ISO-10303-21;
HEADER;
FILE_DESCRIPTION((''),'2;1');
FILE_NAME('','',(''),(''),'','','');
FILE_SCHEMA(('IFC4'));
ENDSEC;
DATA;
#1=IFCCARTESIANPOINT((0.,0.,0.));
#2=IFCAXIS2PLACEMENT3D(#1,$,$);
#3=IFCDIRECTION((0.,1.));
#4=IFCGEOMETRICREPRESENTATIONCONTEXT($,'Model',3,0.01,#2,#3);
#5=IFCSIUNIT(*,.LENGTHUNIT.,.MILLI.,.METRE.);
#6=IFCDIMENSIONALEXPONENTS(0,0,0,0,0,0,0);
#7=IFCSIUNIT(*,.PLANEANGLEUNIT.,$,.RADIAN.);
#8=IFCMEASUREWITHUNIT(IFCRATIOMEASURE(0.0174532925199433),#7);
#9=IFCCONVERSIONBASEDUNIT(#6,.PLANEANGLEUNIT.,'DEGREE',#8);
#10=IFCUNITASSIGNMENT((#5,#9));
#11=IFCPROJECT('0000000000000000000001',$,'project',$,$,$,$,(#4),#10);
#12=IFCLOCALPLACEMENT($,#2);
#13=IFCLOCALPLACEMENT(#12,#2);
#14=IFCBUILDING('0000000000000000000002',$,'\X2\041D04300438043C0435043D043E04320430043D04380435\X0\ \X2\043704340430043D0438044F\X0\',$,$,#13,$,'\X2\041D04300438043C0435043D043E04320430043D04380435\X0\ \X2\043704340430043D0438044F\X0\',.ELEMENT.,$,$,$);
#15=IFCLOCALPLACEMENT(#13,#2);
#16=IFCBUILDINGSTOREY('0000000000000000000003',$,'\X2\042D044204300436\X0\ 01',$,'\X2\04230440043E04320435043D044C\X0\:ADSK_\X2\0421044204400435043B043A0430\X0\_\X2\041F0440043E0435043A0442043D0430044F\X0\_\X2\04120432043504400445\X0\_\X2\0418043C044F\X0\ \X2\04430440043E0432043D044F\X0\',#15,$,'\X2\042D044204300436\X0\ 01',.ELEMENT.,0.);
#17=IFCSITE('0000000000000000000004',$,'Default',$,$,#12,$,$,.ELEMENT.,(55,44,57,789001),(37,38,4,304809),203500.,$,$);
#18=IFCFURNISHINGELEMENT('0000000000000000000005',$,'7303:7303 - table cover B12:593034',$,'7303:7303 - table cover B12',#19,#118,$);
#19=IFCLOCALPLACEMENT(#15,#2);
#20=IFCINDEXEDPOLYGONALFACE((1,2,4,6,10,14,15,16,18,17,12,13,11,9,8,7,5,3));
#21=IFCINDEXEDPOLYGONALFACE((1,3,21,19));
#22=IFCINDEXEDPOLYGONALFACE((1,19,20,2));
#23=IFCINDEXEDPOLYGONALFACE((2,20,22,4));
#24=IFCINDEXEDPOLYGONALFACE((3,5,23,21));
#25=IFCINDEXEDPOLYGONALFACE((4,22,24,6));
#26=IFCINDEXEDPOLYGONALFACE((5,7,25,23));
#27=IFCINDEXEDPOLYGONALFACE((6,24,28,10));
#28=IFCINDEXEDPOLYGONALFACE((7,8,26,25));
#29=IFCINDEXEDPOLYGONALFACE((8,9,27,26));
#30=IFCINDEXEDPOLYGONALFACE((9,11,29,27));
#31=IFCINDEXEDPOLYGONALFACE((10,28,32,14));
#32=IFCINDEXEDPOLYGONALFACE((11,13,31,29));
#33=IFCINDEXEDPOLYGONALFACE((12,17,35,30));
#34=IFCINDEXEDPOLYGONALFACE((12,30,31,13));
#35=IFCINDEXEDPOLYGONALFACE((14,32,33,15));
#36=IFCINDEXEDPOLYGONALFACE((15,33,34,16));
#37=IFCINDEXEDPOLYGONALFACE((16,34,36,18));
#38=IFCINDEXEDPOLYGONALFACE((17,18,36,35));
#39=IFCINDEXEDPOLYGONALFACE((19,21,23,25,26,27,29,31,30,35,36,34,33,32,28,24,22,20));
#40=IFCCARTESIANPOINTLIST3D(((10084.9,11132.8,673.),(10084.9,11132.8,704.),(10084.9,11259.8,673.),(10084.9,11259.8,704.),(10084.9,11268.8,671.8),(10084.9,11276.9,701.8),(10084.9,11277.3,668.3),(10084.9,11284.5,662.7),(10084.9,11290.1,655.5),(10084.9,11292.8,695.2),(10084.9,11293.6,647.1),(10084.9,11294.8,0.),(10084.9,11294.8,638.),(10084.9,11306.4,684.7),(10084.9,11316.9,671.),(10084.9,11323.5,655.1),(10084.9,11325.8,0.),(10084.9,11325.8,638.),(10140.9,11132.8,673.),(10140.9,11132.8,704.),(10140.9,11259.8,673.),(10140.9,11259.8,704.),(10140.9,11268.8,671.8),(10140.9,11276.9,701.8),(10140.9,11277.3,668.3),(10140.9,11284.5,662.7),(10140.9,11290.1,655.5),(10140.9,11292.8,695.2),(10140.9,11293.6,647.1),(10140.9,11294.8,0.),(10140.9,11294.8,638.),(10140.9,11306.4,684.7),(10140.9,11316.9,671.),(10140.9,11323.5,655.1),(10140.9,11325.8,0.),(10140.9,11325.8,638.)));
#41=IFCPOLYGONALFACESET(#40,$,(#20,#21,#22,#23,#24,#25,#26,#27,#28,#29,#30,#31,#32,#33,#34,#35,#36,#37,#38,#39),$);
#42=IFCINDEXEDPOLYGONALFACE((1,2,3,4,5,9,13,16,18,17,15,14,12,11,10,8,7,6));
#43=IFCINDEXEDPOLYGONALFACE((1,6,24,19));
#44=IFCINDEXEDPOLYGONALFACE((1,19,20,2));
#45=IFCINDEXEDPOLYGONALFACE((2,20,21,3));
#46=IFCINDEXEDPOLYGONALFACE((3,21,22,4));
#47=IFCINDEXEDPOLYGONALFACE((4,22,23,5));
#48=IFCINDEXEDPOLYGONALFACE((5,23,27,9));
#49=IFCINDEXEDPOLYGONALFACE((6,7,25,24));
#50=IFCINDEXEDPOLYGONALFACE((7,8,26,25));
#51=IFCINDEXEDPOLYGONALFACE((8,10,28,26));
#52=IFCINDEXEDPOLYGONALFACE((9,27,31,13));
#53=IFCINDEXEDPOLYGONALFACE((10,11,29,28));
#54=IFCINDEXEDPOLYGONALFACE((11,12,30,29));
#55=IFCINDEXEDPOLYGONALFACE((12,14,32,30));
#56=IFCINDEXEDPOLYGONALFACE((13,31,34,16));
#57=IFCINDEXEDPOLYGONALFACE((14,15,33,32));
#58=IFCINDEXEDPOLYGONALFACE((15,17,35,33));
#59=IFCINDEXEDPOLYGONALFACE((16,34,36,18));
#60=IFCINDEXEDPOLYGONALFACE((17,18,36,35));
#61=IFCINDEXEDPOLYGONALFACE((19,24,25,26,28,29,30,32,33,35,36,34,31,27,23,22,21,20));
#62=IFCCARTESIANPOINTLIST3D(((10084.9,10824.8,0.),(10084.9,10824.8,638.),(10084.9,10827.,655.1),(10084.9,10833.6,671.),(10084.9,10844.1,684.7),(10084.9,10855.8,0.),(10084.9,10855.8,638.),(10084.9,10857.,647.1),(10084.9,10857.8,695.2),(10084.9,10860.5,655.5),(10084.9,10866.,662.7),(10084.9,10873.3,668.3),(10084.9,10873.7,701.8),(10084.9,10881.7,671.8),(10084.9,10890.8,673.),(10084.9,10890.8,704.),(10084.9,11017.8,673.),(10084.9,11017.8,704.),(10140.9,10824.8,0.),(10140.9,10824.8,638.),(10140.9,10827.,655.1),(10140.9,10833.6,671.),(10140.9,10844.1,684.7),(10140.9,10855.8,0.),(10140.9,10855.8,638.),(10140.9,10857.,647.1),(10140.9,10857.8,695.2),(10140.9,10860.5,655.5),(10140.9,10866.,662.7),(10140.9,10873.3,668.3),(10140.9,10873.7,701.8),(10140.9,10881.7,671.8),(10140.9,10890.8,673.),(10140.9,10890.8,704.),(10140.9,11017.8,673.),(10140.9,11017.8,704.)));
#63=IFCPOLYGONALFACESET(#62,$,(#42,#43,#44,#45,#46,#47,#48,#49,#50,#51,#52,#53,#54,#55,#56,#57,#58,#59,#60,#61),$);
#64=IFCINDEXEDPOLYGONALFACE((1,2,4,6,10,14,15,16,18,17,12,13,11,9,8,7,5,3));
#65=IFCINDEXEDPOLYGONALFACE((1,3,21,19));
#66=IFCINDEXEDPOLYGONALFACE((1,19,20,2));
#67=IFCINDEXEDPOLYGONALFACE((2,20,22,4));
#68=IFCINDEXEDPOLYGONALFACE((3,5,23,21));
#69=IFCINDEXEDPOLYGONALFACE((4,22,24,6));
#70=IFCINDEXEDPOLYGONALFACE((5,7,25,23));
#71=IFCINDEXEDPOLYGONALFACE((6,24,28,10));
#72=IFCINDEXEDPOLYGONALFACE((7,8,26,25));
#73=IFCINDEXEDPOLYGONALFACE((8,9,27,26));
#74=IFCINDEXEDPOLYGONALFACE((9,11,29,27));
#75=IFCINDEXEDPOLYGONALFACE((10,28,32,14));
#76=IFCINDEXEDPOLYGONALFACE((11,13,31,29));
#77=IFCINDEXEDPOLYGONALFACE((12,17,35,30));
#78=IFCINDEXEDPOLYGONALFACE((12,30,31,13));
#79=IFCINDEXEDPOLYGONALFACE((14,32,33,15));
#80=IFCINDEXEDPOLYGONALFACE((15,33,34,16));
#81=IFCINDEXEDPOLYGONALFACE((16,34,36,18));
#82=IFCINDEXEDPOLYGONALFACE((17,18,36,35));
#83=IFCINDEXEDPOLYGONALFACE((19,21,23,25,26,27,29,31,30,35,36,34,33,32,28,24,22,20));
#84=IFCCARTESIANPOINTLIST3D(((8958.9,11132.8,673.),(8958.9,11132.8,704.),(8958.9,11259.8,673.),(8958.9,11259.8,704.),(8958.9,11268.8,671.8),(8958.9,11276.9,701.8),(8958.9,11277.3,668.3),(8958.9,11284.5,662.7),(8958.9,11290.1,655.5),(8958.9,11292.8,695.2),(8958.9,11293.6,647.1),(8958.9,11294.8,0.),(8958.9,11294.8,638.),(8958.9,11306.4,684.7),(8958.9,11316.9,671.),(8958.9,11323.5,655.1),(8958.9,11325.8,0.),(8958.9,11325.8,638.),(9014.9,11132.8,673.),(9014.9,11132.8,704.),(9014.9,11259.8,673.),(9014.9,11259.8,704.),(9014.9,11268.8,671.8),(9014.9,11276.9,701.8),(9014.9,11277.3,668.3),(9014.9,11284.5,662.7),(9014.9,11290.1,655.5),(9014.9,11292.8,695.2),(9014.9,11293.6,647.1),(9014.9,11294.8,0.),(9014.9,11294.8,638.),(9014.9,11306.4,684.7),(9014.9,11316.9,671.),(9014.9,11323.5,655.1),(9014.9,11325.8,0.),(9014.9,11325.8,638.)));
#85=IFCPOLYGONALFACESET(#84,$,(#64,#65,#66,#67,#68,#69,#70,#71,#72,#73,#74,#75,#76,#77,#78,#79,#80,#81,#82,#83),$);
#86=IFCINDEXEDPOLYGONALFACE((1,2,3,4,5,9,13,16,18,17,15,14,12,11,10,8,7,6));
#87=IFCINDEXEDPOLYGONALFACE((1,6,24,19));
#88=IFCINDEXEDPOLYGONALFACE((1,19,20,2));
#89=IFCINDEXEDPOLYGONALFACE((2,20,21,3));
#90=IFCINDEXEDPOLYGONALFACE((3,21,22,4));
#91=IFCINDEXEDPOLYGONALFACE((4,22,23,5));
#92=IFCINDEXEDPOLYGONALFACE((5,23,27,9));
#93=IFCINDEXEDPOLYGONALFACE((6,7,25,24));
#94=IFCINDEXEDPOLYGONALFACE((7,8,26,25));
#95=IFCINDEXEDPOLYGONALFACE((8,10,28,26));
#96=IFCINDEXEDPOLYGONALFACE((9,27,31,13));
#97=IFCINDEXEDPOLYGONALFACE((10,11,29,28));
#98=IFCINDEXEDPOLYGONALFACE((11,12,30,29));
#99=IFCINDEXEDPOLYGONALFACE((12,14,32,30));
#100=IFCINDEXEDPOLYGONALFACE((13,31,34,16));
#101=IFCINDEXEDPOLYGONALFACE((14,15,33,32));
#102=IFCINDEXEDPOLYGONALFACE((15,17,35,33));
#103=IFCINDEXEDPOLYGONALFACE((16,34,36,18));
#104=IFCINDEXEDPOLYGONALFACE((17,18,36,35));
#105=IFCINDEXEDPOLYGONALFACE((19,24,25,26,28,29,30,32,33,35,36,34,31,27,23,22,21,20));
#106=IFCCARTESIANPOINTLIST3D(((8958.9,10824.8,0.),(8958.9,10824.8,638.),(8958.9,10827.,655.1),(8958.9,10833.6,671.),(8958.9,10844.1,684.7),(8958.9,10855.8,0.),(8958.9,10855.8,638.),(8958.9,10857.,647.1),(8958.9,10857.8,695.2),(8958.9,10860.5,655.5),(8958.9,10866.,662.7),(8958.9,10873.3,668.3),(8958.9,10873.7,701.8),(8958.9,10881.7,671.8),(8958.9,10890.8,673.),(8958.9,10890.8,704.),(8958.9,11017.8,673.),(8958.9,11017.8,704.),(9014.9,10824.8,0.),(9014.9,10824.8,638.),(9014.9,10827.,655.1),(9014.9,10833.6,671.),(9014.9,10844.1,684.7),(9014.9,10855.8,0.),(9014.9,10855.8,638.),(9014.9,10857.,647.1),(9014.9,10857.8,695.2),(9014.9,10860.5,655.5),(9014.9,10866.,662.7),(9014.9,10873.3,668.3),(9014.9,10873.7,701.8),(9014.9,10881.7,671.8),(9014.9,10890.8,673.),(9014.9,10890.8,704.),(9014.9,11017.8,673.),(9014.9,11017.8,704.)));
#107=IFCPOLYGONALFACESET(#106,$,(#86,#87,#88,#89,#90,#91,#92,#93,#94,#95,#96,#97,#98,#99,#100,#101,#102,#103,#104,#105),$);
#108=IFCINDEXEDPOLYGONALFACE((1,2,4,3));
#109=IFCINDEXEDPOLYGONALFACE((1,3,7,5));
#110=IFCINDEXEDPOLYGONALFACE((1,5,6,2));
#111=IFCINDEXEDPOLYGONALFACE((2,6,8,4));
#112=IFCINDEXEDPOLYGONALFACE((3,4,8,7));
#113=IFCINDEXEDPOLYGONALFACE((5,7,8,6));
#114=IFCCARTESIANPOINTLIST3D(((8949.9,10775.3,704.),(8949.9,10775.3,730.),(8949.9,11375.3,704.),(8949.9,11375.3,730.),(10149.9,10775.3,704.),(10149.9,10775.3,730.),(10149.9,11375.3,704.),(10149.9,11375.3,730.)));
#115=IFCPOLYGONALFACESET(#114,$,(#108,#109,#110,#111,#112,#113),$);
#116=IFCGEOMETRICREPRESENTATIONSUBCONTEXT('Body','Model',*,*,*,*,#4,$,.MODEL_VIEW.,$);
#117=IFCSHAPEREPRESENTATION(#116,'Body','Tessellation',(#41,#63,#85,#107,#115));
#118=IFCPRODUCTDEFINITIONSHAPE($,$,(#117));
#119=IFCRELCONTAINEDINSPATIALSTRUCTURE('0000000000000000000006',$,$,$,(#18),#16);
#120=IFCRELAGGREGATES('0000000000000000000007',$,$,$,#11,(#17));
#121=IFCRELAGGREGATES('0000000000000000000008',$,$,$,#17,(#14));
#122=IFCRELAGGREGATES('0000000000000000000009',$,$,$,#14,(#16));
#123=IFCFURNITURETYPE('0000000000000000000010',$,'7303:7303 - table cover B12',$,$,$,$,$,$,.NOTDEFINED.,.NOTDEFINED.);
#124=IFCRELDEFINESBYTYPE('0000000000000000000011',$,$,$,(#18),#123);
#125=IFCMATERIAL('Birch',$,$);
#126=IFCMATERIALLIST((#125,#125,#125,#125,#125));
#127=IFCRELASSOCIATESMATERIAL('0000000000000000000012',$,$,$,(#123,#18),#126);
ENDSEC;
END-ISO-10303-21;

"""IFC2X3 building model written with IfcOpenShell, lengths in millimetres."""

from ifc_helpers import new_model, entity, si_unit, converted_unit, direction, frame, frame_2d, origin, origin_2d_with_axis, place, context, subcontext, project, spatial, polyline, circle_curve, parameter, trimmed, segment, composite_curve, rectangle, outline, extrude, source, transform, mapped, material, material_list, type_object, type_shapes, element, save


model = new_model("IFC2X3")

# Units and contexts
model_context = context("Model", 3, precision=0.01, world=origin(), true_north=direction((0.0, 1.0)))
body_context = subcontext(model_context, "Body", "Model", "MODEL_VIEW")
ifc_project = project(units=[si_unit("LENGTHUNIT", "METRE", prefix="MILLI"), converted_unit("PLANEANGLEUNIT", "DEGREE", entity("IfcRatioMeasure", 0.0174532925199433), si_unit("PLANEANGLEUNIT", "RADIAN"), dimensions=[0, 0, 0, 0, 0, 0, 0])], contexts=[model_context])

# Site, building, storey
site_placement = place(None, origin())
site = spatial("IfcSite", under=ifc_project, at=site_placement, Name="Default", CompositionType="ELEMENT", RefLatitude=(55, 44, 57, 789001), RefLongitude=(37, 38, 4, 304809), RefElevation=203500.0)
building_placement = place(site_placement, origin())
building = spatial("IfcBuilding", under=site, at=building_placement, Name="Наименование здания", LongName="Наименование здания", CompositionType="ELEMENT")
storey_placement = place(building_placement, origin())
storey = spatial("IfcBuildingStorey", under=building, at=storey_placement, Name="Этаж 01", ObjectType="Уровень:ADSK_Стрелка_Проектная_Вверх_Имя уровня", LongName="Этаж 01", CompositionType="ELEMENT", Elevation=0.0)

# Furnishing element
ifc_material_1 = material(Name="Birch")
ifc_material_list_1 = material_list([ifc_material_1, ifc_material_1, ifc_material_1, ifc_material_1, ifc_material_1])
furniture_type = type_object("IfcFurnitureType", Name="7303:7303 - table cover B12", material=ifc_material_list_1)
shared_shape_1 = source(origin(), body_context, "Body", "SweptSolid", [
    extrude(outline(composite_curve([segment(polyline([(-200.2, -120.5), (-169.2, -120.5)]), True, "CONTINUOUS"), segment(polyline([(-169.2, -120.5), (-169.2, 6.5)]), True, "CONTINUOUS"), segment(trimmed(circle_curve(frame_2d((-134.2, 6.5), x_axis=(0.0, -1.0)), 35.0), [parameter(180.0)], [parameter(270.0)], True, "PARAMETER"), False, "CONTINUOUS"), segment(polyline([(-134.2, 41.5), (503.8, 41.5)]), True, "CONTINUOUS"), segment(polyline([(503.8, 41.5), (503.8, 72.5)]), True, "CONTINUOUS"), segment(polyline([(503.8, 72.5), (-134.2, 72.5)]), True, "CONTINUOUS"), segment(trimmed(circle_curve(frame_2d((-134.2, 6.5), x_axis=(0.0, -1.0)), 66.0), [parameter(180.0)], [parameter(270.0)], True, "PARAMETER"), True, "CONTINUOUS"), segment(polyline([(-200.2, 6.5), (-200.2, -120.5)]), True, "CONTINUOUS")], self_intersect=False)), frame((535.0, 178.0, 503.8), z_axis=(1.0, 0.0, 0.0), x_axis=(0.0, 0.0, -1.0)), (0.0, 0.0, 1.0), 56.0),
    extrude(outline(composite_curve([segment(polyline([(-120.5, -200.2), (6.5, -200.2)]), True, "CONTINUOUS"), segment(trimmed(circle_curve(frame_2d((6.5, -134.2), x_axis=(-1.0, 0.0)), 66.0), [parameter(90.0)], [parameter(180.0)], True, "PARAMETER"), True, "CONTINUOUS"), segment(polyline([(72.5, -134.2), (72.5, 503.8)]), True, "CONTINUOUS"), segment(polyline([(72.5, 503.8), (41.5, 503.8)]), True, "CONTINUOUS"), segment(polyline([(41.5, 503.8), (41.5, -134.2)]), True, "CONTINUOUS"), segment(trimmed(circle_curve(frame_2d((6.5, -134.2), x_axis=(-1.0, 0.0)), 35.0), [parameter(90.0)], [parameter(180.0)], True, "PARAMETER"), False, "CONTINUOUS"), segment(polyline([(6.5, -169.2), (-120.5, -169.2)]), True, "CONTINUOUS"), segment(polyline([(-120.5, -169.2), (-120.5, -200.2)]), True, "CONTINUOUS")], self_intersect=False)), frame((535.0, -178.0, 503.8), z_axis=(1.0, 0.0, 0.0), x_axis=(0.0, -1.0, 0.0)), (0.0, 0.0, 1.0), 56.0),
    extrude(outline(composite_curve([segment(polyline([(-200.2, -120.5), (-169.2, -120.5)]), True, "CONTINUOUS"), segment(polyline([(-169.2, -120.5), (-169.2, 6.5)]), True, "CONTINUOUS"), segment(trimmed(circle_curve(frame_2d((-134.2, 6.5), x_axis=(0.0, -1.0)), 35.0), [parameter(180.0)], [parameter(270.0)], True, "PARAMETER"), False, "CONTINUOUS"), segment(polyline([(-134.2, 41.5), (503.8, 41.5)]), True, "CONTINUOUS"), segment(polyline([(503.8, 41.5), (503.8, 72.5)]), True, "CONTINUOUS"), segment(polyline([(503.8, 72.5), (-134.2, 72.5)]), True, "CONTINUOUS"), segment(trimmed(circle_curve(frame_2d((-134.2, 6.5), x_axis=(0.0, -1.0)), 66.0), [parameter(180.0)], [parameter(270.0)], True, "PARAMETER"), True, "CONTINUOUS"), segment(polyline([(-200.2, 6.5), (-200.2, -120.5)]), True, "CONTINUOUS")], self_intersect=False)), frame((-591.0, 178.0, 503.8), z_axis=(1.0, 0.0, 0.0), x_axis=(0.0, 0.0, -1.0)), (0.0, 0.0, 1.0), 56.0),
    extrude(outline(composite_curve([segment(polyline([(-120.5, -200.2), (6.5, -200.2)]), True, "CONTINUOUS"), segment(trimmed(circle_curve(frame_2d((6.5, -134.2), x_axis=(-1.0, 0.0)), 66.0), [parameter(90.0)], [parameter(180.0)], True, "PARAMETER"), True, "CONTINUOUS"), segment(polyline([(72.5, -134.2), (72.5, 503.8)]), True, "CONTINUOUS"), segment(polyline([(72.5, 503.8), (41.5, 503.8)]), True, "CONTINUOUS"), segment(polyline([(41.5, 503.8), (41.5, -134.2)]), True, "CONTINUOUS"), segment(trimmed(circle_curve(frame_2d((6.5, -134.2), x_axis=(-1.0, 0.0)), 35.0), [parameter(90.0)], [parameter(180.0)], True, "PARAMETER"), False, "CONTINUOUS"), segment(polyline([(6.5, -169.2), (-120.5, -169.2)]), True, "CONTINUOUS"), segment(polyline([(-120.5, -169.2), (-120.5, -200.2)]), True, "CONTINUOUS")], self_intersect=False)), frame((-591.0, -178.0, 503.8), z_axis=(1.0, 0.0, 0.0), x_axis=(0.0, -1.0, 0.0)), (0.0, 0.0, 1.0), 56.0),
    extrude(rectangle(XDim=1200.0, YDim=600.0, at=origin_2d_with_axis()), frame((0.0, 0.0, 704.0), z_axis=(0.0, 0.0, 1.0), x_axis=(-1.0, 0.0, 0.0)), (0.0, 0.0, 1.0), 26.0),
])
type_shapes(furniture_type, [shared_shape_1])
furnishing_placement = place(storey_placement, frame((9549.9, 11075.3, 0.0)))
element("IfcFurnishingElement", 1, at=furnishing_placement, inside=storey, type_object=furniture_type, material=ifc_material_list_1, Name="7303:7303 - table cover B12:593034", ObjectType="7303:7303 - table cover B12", context=body_context, shape_type="MappedRepresentation", body=[
    mapped(shared_shape_1, transform((0.0, 0.0, 0.0), scale=1.0)),
])

save(model, "model.ifc")
